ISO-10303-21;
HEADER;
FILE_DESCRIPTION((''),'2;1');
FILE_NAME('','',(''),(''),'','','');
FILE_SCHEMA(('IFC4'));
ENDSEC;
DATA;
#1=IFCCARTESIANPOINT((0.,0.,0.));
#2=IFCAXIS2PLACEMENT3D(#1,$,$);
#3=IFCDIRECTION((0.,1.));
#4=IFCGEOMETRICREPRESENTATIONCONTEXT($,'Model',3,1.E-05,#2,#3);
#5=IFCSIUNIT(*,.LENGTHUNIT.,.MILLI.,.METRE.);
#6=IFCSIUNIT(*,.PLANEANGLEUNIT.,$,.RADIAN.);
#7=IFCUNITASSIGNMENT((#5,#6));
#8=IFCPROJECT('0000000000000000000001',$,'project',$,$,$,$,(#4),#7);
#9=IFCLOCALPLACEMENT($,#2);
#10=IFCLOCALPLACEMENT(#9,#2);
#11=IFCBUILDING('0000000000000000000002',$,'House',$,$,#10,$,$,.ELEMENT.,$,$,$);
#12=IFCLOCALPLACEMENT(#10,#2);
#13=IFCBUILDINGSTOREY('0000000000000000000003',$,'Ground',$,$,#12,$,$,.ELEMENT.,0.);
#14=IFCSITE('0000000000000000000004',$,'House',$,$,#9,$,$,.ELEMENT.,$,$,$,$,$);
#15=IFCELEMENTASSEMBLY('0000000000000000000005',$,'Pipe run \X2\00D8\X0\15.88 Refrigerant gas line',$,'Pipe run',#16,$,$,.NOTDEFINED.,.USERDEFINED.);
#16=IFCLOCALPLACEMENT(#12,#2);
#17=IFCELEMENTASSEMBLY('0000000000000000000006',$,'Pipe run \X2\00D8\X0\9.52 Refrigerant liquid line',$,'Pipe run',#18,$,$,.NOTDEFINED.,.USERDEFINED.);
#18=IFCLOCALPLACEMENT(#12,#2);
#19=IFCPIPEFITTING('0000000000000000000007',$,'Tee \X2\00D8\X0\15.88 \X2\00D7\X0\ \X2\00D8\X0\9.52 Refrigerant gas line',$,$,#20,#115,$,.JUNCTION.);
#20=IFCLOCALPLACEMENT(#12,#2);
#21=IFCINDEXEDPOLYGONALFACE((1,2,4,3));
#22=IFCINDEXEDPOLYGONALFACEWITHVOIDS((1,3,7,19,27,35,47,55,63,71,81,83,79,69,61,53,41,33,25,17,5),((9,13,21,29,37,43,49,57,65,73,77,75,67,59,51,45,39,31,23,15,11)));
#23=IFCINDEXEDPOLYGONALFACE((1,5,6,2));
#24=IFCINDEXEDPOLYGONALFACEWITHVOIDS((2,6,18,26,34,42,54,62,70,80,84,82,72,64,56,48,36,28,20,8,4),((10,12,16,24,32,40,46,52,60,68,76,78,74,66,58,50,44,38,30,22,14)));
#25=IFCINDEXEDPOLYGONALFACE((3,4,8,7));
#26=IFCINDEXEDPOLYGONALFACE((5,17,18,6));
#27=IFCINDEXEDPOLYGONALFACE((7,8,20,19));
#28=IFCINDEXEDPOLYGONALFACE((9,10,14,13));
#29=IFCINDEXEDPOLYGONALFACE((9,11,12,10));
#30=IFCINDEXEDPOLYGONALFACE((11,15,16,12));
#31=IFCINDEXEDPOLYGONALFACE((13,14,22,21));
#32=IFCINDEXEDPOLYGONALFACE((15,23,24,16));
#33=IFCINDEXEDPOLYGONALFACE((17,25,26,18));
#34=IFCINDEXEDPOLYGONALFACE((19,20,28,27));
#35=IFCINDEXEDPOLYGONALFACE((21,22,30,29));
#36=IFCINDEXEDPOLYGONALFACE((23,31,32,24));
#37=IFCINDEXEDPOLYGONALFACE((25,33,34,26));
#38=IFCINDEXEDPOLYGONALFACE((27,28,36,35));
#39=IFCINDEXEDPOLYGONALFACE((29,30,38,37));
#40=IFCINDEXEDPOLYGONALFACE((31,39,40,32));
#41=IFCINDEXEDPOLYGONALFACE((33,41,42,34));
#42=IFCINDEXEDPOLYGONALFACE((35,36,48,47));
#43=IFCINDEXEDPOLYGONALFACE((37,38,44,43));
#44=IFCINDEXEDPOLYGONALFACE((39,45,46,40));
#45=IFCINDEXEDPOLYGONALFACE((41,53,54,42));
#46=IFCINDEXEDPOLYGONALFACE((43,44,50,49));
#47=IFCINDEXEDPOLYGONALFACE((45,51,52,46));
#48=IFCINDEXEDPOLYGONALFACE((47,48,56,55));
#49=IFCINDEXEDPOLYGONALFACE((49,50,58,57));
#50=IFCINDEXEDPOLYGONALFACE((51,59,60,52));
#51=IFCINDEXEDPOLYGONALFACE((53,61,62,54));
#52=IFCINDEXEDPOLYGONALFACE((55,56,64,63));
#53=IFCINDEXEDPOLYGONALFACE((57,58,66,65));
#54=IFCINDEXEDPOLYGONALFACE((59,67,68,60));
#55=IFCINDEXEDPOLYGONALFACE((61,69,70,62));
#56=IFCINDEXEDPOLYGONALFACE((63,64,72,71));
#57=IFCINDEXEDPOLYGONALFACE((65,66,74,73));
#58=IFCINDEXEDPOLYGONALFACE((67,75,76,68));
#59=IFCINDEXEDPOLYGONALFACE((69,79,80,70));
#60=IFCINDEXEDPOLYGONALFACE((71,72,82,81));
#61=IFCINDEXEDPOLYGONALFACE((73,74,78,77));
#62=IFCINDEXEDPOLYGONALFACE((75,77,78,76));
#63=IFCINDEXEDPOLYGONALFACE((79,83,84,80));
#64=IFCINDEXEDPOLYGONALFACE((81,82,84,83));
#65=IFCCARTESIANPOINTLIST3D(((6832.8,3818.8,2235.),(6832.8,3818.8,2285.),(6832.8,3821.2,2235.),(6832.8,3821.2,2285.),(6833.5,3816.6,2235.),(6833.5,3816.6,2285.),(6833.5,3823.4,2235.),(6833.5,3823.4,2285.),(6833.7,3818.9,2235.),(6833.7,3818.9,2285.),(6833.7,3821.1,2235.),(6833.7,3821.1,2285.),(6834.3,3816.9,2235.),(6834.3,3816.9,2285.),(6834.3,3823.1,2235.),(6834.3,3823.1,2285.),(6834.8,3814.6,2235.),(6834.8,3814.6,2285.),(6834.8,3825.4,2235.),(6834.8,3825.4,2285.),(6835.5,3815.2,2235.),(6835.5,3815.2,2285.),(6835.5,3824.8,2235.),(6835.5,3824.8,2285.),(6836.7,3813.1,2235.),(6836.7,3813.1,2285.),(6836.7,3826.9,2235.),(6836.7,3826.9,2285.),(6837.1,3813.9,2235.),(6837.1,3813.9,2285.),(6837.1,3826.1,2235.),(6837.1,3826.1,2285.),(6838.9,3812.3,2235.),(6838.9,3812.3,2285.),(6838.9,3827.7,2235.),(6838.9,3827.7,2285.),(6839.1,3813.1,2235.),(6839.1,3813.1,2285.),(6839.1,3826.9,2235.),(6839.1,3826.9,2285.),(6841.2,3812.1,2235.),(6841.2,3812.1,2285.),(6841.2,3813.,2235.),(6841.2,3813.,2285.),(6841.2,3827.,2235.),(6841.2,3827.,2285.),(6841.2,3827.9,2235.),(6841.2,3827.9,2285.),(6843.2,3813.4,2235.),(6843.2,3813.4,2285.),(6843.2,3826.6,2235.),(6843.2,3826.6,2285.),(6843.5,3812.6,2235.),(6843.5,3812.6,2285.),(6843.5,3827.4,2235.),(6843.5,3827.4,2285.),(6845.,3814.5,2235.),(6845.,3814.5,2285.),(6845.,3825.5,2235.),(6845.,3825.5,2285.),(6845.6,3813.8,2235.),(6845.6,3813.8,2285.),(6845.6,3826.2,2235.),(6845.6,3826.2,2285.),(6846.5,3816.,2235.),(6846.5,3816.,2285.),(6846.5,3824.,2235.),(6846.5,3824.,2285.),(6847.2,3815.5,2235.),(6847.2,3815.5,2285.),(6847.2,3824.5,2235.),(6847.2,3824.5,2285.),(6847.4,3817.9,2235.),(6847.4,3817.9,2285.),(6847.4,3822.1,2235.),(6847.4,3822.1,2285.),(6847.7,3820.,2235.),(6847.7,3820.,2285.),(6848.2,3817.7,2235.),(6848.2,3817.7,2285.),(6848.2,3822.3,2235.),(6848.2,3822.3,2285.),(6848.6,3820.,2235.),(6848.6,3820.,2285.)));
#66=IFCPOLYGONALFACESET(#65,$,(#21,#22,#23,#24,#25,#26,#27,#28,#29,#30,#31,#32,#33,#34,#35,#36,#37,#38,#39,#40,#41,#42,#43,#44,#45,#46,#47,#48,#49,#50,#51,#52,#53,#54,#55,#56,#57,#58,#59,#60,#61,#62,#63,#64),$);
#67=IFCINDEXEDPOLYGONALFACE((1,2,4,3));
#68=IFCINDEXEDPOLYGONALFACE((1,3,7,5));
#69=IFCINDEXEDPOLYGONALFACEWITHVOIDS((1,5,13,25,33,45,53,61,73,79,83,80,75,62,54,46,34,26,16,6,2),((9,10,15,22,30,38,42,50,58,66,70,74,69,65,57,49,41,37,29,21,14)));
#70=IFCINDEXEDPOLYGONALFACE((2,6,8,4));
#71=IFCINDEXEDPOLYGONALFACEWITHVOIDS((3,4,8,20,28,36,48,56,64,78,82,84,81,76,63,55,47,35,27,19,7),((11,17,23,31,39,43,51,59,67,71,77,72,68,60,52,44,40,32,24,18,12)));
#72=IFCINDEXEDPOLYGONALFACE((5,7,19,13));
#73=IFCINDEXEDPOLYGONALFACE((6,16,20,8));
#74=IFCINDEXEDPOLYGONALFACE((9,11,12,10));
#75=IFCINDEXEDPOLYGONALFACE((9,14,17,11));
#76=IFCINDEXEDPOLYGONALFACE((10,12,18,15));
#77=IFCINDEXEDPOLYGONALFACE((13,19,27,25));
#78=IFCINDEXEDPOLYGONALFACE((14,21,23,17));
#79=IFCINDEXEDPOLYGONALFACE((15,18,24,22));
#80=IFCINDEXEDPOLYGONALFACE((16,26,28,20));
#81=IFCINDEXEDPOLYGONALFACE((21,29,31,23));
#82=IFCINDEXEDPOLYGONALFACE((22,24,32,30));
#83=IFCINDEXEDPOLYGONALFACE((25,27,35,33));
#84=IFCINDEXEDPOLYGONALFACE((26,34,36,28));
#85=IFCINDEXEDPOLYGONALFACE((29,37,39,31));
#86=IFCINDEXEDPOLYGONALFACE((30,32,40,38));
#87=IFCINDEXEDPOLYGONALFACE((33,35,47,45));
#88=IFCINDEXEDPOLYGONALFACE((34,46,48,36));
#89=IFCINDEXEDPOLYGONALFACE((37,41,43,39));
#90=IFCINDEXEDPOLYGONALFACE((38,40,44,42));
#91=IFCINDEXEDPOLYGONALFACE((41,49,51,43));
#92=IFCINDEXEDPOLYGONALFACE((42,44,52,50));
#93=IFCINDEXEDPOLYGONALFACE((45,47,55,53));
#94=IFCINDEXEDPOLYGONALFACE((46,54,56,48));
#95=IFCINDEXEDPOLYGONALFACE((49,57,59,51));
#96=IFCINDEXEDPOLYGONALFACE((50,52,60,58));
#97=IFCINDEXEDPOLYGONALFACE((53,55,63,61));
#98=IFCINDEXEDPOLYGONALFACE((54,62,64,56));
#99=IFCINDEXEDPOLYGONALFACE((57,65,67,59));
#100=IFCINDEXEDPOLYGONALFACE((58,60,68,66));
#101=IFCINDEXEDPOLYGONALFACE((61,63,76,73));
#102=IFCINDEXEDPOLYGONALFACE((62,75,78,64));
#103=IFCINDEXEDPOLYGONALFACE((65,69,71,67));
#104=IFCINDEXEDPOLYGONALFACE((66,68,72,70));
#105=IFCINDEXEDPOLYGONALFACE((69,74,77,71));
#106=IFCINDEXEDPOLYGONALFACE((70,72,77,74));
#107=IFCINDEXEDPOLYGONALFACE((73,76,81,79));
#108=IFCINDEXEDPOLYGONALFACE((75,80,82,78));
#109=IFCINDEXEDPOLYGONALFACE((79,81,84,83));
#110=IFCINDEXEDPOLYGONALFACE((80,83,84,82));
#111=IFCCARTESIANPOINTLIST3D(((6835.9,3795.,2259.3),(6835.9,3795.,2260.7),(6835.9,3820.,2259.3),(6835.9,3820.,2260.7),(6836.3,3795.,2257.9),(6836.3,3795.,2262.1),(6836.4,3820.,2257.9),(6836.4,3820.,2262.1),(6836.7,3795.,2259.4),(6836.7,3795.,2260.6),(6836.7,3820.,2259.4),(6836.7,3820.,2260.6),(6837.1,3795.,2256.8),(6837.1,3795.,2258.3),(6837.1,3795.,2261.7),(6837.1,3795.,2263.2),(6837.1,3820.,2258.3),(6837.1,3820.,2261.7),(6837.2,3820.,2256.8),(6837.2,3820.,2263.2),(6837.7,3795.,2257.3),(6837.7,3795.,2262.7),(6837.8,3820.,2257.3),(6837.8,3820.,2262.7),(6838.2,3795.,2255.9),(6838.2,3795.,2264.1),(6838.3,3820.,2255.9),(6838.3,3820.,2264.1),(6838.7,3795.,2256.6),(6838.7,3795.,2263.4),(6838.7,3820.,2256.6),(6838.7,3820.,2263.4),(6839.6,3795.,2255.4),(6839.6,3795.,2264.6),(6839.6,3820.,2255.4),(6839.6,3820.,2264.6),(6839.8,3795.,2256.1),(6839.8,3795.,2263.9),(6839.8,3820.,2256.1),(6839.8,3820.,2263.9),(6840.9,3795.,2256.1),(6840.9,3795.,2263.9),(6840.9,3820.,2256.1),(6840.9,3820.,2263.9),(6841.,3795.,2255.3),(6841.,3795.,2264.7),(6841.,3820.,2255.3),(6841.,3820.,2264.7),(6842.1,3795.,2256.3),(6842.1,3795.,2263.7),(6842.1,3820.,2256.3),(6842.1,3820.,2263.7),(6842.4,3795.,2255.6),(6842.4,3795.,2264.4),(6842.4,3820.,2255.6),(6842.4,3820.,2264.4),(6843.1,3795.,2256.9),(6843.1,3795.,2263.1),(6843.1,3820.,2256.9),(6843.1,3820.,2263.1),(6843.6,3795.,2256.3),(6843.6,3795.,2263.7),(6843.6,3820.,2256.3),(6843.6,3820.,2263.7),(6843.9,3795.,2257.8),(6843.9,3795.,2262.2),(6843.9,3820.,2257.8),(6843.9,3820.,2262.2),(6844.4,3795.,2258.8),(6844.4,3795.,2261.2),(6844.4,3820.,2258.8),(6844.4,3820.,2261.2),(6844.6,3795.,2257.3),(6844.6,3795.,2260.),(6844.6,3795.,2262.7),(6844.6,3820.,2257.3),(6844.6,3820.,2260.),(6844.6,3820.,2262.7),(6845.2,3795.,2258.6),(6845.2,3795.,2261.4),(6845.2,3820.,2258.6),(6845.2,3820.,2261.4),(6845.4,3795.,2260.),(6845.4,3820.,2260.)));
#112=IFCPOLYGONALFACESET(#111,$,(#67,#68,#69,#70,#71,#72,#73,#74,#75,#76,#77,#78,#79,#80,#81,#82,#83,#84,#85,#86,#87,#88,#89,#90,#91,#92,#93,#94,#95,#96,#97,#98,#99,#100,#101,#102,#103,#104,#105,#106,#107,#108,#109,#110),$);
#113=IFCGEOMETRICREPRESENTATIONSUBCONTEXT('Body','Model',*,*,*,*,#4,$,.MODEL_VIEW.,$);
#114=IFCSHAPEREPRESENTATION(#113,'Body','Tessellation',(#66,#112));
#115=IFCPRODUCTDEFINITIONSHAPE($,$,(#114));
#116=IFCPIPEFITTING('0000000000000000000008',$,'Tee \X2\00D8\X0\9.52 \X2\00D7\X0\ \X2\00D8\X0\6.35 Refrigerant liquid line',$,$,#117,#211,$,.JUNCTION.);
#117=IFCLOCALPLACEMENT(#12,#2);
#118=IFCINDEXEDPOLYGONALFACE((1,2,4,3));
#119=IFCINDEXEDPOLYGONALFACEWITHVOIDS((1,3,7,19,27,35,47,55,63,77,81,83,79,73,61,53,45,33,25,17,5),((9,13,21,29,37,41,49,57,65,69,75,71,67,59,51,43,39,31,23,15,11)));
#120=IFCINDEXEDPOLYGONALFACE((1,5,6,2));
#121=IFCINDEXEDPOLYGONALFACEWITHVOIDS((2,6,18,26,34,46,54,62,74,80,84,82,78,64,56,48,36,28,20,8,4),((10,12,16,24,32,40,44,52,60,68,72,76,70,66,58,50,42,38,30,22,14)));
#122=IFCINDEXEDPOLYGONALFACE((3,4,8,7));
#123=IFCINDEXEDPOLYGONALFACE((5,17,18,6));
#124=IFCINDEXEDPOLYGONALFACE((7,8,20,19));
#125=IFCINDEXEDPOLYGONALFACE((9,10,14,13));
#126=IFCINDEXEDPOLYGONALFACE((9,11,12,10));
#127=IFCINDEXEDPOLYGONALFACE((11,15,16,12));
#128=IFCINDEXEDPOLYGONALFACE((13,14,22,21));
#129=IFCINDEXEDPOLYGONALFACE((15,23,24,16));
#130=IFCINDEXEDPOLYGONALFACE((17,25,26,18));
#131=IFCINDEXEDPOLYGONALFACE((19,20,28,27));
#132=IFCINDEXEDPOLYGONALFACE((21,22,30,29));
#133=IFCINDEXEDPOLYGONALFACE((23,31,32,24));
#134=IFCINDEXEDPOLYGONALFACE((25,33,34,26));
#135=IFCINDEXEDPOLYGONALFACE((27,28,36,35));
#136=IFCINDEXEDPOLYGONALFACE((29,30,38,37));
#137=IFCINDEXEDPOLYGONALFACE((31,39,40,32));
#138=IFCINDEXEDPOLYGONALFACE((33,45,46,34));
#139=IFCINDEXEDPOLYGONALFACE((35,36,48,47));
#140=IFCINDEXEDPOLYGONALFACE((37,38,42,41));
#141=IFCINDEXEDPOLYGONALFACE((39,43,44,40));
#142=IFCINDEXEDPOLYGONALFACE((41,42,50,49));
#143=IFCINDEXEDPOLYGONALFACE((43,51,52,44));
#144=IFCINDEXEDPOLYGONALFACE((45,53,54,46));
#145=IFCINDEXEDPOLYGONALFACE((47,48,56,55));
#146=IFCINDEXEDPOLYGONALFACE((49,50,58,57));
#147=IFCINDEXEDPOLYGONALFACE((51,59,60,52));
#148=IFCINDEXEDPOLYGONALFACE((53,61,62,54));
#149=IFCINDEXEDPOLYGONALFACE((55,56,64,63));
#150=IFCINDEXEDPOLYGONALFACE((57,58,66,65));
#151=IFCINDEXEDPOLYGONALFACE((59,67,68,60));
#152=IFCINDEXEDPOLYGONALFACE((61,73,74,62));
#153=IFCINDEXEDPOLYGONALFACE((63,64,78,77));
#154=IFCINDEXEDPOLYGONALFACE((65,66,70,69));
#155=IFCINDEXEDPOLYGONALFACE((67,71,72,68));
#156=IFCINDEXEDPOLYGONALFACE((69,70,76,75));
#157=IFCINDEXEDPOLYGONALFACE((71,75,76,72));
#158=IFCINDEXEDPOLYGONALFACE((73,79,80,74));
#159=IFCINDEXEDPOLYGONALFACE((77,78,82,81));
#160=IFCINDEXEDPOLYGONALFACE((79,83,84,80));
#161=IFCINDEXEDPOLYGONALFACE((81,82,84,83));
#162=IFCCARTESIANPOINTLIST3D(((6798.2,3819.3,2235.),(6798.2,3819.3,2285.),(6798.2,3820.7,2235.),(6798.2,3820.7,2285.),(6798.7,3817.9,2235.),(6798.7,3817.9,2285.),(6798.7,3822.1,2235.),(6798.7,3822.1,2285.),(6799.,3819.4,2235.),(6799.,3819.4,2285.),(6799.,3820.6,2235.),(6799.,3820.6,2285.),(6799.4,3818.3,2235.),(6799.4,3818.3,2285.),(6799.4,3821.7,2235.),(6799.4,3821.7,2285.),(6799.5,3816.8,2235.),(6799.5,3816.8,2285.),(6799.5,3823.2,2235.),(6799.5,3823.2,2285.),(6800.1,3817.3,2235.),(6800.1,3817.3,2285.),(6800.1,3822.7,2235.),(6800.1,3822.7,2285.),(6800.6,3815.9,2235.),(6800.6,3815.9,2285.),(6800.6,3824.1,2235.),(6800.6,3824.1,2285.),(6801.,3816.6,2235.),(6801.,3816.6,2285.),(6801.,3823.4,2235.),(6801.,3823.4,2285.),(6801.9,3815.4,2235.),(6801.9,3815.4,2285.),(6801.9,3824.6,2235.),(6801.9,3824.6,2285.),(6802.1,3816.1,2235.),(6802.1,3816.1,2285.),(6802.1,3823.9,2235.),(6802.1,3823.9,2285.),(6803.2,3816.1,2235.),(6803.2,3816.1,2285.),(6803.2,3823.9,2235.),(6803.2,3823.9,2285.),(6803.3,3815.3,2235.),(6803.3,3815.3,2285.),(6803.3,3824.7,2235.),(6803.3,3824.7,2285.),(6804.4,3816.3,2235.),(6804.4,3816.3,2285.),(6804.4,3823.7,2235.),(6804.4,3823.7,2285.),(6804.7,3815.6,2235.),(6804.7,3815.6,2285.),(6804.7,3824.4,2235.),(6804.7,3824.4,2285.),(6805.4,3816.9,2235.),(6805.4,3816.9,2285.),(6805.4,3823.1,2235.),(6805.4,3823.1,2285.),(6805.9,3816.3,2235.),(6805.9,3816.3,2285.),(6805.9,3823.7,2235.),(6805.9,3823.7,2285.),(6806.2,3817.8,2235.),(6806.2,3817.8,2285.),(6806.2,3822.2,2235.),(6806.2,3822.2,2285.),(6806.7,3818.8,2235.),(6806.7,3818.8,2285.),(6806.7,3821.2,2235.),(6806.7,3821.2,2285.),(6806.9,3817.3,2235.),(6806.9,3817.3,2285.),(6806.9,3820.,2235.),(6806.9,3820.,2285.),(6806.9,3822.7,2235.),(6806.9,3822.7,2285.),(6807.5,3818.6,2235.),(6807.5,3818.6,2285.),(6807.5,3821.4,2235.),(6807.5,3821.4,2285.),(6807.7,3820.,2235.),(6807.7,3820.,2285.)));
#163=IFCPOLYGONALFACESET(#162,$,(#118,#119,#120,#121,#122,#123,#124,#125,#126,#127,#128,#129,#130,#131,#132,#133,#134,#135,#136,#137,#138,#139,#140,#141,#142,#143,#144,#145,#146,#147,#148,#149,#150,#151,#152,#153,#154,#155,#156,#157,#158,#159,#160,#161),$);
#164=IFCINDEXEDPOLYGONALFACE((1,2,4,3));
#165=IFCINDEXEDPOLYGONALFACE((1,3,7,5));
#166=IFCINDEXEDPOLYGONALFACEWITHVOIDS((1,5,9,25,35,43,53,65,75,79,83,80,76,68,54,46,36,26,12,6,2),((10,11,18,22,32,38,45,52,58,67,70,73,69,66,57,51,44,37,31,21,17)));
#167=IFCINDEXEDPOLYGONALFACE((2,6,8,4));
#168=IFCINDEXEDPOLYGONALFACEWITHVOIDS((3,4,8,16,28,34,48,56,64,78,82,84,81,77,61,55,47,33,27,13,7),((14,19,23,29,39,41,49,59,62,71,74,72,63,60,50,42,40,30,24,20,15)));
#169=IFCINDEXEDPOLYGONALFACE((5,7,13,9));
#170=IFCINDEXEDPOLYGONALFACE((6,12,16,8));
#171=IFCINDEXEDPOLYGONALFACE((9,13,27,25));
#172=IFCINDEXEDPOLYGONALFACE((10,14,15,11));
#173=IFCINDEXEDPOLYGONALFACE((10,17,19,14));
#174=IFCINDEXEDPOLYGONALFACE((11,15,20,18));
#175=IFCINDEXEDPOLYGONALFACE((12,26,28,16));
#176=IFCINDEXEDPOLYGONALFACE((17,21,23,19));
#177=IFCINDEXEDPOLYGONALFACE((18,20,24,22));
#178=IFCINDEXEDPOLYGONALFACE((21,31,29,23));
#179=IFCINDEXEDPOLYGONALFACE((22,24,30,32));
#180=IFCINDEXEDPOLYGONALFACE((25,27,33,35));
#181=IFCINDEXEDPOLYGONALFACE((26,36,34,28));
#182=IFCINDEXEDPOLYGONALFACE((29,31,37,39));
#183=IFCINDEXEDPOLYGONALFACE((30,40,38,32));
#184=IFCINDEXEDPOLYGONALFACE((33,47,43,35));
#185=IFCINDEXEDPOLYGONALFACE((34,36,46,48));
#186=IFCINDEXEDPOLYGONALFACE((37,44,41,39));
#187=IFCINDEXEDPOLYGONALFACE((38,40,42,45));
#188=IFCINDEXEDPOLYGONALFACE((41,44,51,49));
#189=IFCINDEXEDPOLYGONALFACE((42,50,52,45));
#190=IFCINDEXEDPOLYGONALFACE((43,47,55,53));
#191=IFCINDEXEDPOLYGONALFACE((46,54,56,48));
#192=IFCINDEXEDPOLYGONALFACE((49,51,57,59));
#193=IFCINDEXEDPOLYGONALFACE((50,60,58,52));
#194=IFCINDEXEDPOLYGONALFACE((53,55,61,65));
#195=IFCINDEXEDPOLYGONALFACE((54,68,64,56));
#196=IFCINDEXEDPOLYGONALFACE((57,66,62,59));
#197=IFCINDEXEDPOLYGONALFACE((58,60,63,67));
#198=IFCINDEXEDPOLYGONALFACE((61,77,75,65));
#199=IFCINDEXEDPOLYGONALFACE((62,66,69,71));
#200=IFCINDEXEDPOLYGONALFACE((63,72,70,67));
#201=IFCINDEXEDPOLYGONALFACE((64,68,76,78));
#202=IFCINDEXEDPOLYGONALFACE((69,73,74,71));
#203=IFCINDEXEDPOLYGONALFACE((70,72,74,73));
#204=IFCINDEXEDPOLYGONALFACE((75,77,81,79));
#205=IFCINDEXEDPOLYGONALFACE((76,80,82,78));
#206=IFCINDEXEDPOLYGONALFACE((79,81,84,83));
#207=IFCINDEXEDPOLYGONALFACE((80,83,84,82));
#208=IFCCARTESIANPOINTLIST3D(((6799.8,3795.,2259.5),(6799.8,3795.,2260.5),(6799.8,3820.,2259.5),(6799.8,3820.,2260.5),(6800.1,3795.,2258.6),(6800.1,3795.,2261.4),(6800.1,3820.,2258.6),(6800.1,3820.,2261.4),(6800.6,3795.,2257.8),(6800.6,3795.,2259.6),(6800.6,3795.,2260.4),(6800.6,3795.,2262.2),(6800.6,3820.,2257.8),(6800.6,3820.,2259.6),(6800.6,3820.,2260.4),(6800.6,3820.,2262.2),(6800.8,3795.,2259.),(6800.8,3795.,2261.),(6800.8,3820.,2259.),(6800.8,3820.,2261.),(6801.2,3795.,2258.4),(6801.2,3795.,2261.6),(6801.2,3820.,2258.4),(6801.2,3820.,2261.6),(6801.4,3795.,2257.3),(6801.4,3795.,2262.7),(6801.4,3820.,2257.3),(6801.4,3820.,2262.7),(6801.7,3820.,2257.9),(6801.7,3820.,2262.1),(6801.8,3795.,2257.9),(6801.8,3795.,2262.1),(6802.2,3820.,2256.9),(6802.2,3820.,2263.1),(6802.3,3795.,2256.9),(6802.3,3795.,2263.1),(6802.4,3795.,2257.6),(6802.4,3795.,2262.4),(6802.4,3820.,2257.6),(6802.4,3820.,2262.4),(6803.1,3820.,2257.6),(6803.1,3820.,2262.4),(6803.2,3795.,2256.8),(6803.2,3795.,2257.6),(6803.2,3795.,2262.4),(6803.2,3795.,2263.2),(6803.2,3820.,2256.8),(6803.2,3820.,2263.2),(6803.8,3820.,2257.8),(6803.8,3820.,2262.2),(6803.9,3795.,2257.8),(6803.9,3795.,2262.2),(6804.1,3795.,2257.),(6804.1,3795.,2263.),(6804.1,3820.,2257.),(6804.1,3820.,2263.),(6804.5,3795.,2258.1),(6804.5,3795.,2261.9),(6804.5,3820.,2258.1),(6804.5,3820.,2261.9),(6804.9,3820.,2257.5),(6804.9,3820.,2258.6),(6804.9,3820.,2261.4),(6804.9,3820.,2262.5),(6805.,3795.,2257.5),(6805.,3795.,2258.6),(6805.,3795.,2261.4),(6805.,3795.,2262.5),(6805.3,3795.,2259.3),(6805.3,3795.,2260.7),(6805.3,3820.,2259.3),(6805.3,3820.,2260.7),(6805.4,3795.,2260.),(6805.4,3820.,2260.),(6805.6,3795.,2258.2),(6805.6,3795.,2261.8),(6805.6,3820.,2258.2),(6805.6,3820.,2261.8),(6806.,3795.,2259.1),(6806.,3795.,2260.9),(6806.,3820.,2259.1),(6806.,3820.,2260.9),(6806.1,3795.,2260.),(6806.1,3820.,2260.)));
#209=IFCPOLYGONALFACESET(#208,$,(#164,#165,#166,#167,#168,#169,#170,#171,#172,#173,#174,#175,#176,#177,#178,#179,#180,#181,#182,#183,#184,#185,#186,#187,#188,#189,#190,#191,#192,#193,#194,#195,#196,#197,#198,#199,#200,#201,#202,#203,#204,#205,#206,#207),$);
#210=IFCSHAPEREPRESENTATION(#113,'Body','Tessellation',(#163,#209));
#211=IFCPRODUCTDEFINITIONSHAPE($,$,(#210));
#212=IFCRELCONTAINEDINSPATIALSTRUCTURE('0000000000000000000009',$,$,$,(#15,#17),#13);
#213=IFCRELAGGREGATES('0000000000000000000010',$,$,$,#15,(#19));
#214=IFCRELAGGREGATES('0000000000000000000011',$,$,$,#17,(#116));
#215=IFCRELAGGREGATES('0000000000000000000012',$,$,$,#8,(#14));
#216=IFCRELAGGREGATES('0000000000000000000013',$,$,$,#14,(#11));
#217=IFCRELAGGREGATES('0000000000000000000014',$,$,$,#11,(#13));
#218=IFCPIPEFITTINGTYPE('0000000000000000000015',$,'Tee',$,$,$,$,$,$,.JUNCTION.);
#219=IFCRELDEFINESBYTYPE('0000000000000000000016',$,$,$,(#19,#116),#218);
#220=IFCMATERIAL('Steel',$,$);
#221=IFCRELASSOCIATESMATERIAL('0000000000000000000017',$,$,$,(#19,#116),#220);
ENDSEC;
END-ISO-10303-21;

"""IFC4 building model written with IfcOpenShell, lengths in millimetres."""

from ifc_helpers import new_model, si_unit, direction, frame, origin, origin_with_axes, origin_2d, place, context, subcontext, project, spatial, hollow_circle, extrude, material, type_object, element, aggregate, save


model = new_model("IFC4")

# Units and contexts
model_context = context("Model", 3, precision=1e-05, world=origin(), true_north=direction((0.0, 1.0)))
body_context = subcontext(model_context, "Body", "Model", "MODEL_VIEW")
ifc_project = project(units=[si_unit("LENGTHUNIT", "METRE", prefix="MILLI"), si_unit("PLANEANGLEUNIT", "RADIAN")], contexts=[model_context])

# Site, building, storey
site_placement = place(None, origin())
site = spatial("IfcSite", under=ifc_project, at=site_placement, Name="House", CompositionType="ELEMENT")
building_placement = place(site_placement, origin())
building = spatial("IfcBuilding", under=site, at=building_placement, Name="House", CompositionType="ELEMENT")
storey_placement = place(building_placement, origin())
storey = spatial("IfcBuildingStorey", under=building, at=storey_placement, Name="Ground", CompositionType="ELEMENT", Elevation=0.0)

# Element assemblies
ifc_material = material(Name="Steel")
assembly_1_placement = place(storey_placement, origin_with_axes())
assembly_1 = element("IfcElementAssembly", 1, at=assembly_1_placement, inside=storey, Name="Pipe run Ø15.88 Refrigerant gas line", ObjectType="Pipe run", AssemblyPlace="NOTDEFINED", PredefinedType="USERDEFINED")
assembly_2_placement = place(storey_placement, origin_with_axes())
assembly_2 = element("IfcElementAssembly", 2, at=assembly_2_placement, inside=storey, Name="Pipe run Ø9.52 Refrigerant liquid line", ObjectType="Pipe run", AssemblyPlace="NOTDEFINED", PredefinedType="USERDEFINED")

# Pipe fittings
pipe_fitting_type_1 = type_object("IfcPipeFittingType", Name="Tee", PredefinedType="JUNCTION")
pipe_fitting_1_placement = place(storey_placement, origin_with_axes())
pipe_fitting_1 = element("IfcPipeFitting", 3, at=pipe_fitting_1_placement, type_object=pipe_fitting_type_1, material=ifc_material, Name="Tee Ø15.88 × Ø9.52 Refrigerant gas line", PredefinedType="JUNCTION", context=body_context, shape_type="SweptSolid", body=[
    extrude(hollow_circle(Radius=7.9, WallThickness=0.9, at=origin_2d()), frame((6840.6, 3820.0, 2235.0), z_axis=(0.0, 0.0, 1.0), x_axis=(1.0, 0.0, 0.0)), (0.0, 0.0, 1.0), 50.0),
    extrude(hollow_circle(Radius=4.8, WallThickness=0.8, at=origin_2d()), frame((6840.6, 3820.0, 2260.0), z_axis=(-0.000825, -1.0, 0.0), x_axis=(1.0, -0.000825, 0.0)), (0.0, 0.0, 1.0), 25.0),
])
aggregate(assembly_1, [pipe_fitting_1])
pipe_fitting_2_placement = place(storey_placement, origin_with_axes())
pipe_fitting_2 = element("IfcPipeFitting", 4, at=pipe_fitting_2_placement, type_object=pipe_fitting_type_1, material=ifc_material, Name="Tee Ø9.52 × Ø6.35 Refrigerant liquid line", PredefinedType="JUNCTION", context=body_context, shape_type="SweptSolid", body=[
    extrude(hollow_circle(Radius=4.8, WallThickness=0.8, at=origin_2d()), frame((6802.9, 3820.0, 2235.0), z_axis=(0.0, 0.0, 1.0), x_axis=(1.0, 0.0, 0.0)), (0.0, 0.0, 1.0), 50.0),
    extrude(hollow_circle(Radius=3.2, WallThickness=0.8, at=origin_2d()), frame((6802.9, 3820.0, 2260.0), z_axis=(0.000834, -1.0, 0.0), x_axis=(1.0, 0.000834, 0.0)), (0.0, 0.0, 1.0), 25.0),
])
aggregate(assembly_2, [pipe_fitting_2])

save(model, "model.ifc")
